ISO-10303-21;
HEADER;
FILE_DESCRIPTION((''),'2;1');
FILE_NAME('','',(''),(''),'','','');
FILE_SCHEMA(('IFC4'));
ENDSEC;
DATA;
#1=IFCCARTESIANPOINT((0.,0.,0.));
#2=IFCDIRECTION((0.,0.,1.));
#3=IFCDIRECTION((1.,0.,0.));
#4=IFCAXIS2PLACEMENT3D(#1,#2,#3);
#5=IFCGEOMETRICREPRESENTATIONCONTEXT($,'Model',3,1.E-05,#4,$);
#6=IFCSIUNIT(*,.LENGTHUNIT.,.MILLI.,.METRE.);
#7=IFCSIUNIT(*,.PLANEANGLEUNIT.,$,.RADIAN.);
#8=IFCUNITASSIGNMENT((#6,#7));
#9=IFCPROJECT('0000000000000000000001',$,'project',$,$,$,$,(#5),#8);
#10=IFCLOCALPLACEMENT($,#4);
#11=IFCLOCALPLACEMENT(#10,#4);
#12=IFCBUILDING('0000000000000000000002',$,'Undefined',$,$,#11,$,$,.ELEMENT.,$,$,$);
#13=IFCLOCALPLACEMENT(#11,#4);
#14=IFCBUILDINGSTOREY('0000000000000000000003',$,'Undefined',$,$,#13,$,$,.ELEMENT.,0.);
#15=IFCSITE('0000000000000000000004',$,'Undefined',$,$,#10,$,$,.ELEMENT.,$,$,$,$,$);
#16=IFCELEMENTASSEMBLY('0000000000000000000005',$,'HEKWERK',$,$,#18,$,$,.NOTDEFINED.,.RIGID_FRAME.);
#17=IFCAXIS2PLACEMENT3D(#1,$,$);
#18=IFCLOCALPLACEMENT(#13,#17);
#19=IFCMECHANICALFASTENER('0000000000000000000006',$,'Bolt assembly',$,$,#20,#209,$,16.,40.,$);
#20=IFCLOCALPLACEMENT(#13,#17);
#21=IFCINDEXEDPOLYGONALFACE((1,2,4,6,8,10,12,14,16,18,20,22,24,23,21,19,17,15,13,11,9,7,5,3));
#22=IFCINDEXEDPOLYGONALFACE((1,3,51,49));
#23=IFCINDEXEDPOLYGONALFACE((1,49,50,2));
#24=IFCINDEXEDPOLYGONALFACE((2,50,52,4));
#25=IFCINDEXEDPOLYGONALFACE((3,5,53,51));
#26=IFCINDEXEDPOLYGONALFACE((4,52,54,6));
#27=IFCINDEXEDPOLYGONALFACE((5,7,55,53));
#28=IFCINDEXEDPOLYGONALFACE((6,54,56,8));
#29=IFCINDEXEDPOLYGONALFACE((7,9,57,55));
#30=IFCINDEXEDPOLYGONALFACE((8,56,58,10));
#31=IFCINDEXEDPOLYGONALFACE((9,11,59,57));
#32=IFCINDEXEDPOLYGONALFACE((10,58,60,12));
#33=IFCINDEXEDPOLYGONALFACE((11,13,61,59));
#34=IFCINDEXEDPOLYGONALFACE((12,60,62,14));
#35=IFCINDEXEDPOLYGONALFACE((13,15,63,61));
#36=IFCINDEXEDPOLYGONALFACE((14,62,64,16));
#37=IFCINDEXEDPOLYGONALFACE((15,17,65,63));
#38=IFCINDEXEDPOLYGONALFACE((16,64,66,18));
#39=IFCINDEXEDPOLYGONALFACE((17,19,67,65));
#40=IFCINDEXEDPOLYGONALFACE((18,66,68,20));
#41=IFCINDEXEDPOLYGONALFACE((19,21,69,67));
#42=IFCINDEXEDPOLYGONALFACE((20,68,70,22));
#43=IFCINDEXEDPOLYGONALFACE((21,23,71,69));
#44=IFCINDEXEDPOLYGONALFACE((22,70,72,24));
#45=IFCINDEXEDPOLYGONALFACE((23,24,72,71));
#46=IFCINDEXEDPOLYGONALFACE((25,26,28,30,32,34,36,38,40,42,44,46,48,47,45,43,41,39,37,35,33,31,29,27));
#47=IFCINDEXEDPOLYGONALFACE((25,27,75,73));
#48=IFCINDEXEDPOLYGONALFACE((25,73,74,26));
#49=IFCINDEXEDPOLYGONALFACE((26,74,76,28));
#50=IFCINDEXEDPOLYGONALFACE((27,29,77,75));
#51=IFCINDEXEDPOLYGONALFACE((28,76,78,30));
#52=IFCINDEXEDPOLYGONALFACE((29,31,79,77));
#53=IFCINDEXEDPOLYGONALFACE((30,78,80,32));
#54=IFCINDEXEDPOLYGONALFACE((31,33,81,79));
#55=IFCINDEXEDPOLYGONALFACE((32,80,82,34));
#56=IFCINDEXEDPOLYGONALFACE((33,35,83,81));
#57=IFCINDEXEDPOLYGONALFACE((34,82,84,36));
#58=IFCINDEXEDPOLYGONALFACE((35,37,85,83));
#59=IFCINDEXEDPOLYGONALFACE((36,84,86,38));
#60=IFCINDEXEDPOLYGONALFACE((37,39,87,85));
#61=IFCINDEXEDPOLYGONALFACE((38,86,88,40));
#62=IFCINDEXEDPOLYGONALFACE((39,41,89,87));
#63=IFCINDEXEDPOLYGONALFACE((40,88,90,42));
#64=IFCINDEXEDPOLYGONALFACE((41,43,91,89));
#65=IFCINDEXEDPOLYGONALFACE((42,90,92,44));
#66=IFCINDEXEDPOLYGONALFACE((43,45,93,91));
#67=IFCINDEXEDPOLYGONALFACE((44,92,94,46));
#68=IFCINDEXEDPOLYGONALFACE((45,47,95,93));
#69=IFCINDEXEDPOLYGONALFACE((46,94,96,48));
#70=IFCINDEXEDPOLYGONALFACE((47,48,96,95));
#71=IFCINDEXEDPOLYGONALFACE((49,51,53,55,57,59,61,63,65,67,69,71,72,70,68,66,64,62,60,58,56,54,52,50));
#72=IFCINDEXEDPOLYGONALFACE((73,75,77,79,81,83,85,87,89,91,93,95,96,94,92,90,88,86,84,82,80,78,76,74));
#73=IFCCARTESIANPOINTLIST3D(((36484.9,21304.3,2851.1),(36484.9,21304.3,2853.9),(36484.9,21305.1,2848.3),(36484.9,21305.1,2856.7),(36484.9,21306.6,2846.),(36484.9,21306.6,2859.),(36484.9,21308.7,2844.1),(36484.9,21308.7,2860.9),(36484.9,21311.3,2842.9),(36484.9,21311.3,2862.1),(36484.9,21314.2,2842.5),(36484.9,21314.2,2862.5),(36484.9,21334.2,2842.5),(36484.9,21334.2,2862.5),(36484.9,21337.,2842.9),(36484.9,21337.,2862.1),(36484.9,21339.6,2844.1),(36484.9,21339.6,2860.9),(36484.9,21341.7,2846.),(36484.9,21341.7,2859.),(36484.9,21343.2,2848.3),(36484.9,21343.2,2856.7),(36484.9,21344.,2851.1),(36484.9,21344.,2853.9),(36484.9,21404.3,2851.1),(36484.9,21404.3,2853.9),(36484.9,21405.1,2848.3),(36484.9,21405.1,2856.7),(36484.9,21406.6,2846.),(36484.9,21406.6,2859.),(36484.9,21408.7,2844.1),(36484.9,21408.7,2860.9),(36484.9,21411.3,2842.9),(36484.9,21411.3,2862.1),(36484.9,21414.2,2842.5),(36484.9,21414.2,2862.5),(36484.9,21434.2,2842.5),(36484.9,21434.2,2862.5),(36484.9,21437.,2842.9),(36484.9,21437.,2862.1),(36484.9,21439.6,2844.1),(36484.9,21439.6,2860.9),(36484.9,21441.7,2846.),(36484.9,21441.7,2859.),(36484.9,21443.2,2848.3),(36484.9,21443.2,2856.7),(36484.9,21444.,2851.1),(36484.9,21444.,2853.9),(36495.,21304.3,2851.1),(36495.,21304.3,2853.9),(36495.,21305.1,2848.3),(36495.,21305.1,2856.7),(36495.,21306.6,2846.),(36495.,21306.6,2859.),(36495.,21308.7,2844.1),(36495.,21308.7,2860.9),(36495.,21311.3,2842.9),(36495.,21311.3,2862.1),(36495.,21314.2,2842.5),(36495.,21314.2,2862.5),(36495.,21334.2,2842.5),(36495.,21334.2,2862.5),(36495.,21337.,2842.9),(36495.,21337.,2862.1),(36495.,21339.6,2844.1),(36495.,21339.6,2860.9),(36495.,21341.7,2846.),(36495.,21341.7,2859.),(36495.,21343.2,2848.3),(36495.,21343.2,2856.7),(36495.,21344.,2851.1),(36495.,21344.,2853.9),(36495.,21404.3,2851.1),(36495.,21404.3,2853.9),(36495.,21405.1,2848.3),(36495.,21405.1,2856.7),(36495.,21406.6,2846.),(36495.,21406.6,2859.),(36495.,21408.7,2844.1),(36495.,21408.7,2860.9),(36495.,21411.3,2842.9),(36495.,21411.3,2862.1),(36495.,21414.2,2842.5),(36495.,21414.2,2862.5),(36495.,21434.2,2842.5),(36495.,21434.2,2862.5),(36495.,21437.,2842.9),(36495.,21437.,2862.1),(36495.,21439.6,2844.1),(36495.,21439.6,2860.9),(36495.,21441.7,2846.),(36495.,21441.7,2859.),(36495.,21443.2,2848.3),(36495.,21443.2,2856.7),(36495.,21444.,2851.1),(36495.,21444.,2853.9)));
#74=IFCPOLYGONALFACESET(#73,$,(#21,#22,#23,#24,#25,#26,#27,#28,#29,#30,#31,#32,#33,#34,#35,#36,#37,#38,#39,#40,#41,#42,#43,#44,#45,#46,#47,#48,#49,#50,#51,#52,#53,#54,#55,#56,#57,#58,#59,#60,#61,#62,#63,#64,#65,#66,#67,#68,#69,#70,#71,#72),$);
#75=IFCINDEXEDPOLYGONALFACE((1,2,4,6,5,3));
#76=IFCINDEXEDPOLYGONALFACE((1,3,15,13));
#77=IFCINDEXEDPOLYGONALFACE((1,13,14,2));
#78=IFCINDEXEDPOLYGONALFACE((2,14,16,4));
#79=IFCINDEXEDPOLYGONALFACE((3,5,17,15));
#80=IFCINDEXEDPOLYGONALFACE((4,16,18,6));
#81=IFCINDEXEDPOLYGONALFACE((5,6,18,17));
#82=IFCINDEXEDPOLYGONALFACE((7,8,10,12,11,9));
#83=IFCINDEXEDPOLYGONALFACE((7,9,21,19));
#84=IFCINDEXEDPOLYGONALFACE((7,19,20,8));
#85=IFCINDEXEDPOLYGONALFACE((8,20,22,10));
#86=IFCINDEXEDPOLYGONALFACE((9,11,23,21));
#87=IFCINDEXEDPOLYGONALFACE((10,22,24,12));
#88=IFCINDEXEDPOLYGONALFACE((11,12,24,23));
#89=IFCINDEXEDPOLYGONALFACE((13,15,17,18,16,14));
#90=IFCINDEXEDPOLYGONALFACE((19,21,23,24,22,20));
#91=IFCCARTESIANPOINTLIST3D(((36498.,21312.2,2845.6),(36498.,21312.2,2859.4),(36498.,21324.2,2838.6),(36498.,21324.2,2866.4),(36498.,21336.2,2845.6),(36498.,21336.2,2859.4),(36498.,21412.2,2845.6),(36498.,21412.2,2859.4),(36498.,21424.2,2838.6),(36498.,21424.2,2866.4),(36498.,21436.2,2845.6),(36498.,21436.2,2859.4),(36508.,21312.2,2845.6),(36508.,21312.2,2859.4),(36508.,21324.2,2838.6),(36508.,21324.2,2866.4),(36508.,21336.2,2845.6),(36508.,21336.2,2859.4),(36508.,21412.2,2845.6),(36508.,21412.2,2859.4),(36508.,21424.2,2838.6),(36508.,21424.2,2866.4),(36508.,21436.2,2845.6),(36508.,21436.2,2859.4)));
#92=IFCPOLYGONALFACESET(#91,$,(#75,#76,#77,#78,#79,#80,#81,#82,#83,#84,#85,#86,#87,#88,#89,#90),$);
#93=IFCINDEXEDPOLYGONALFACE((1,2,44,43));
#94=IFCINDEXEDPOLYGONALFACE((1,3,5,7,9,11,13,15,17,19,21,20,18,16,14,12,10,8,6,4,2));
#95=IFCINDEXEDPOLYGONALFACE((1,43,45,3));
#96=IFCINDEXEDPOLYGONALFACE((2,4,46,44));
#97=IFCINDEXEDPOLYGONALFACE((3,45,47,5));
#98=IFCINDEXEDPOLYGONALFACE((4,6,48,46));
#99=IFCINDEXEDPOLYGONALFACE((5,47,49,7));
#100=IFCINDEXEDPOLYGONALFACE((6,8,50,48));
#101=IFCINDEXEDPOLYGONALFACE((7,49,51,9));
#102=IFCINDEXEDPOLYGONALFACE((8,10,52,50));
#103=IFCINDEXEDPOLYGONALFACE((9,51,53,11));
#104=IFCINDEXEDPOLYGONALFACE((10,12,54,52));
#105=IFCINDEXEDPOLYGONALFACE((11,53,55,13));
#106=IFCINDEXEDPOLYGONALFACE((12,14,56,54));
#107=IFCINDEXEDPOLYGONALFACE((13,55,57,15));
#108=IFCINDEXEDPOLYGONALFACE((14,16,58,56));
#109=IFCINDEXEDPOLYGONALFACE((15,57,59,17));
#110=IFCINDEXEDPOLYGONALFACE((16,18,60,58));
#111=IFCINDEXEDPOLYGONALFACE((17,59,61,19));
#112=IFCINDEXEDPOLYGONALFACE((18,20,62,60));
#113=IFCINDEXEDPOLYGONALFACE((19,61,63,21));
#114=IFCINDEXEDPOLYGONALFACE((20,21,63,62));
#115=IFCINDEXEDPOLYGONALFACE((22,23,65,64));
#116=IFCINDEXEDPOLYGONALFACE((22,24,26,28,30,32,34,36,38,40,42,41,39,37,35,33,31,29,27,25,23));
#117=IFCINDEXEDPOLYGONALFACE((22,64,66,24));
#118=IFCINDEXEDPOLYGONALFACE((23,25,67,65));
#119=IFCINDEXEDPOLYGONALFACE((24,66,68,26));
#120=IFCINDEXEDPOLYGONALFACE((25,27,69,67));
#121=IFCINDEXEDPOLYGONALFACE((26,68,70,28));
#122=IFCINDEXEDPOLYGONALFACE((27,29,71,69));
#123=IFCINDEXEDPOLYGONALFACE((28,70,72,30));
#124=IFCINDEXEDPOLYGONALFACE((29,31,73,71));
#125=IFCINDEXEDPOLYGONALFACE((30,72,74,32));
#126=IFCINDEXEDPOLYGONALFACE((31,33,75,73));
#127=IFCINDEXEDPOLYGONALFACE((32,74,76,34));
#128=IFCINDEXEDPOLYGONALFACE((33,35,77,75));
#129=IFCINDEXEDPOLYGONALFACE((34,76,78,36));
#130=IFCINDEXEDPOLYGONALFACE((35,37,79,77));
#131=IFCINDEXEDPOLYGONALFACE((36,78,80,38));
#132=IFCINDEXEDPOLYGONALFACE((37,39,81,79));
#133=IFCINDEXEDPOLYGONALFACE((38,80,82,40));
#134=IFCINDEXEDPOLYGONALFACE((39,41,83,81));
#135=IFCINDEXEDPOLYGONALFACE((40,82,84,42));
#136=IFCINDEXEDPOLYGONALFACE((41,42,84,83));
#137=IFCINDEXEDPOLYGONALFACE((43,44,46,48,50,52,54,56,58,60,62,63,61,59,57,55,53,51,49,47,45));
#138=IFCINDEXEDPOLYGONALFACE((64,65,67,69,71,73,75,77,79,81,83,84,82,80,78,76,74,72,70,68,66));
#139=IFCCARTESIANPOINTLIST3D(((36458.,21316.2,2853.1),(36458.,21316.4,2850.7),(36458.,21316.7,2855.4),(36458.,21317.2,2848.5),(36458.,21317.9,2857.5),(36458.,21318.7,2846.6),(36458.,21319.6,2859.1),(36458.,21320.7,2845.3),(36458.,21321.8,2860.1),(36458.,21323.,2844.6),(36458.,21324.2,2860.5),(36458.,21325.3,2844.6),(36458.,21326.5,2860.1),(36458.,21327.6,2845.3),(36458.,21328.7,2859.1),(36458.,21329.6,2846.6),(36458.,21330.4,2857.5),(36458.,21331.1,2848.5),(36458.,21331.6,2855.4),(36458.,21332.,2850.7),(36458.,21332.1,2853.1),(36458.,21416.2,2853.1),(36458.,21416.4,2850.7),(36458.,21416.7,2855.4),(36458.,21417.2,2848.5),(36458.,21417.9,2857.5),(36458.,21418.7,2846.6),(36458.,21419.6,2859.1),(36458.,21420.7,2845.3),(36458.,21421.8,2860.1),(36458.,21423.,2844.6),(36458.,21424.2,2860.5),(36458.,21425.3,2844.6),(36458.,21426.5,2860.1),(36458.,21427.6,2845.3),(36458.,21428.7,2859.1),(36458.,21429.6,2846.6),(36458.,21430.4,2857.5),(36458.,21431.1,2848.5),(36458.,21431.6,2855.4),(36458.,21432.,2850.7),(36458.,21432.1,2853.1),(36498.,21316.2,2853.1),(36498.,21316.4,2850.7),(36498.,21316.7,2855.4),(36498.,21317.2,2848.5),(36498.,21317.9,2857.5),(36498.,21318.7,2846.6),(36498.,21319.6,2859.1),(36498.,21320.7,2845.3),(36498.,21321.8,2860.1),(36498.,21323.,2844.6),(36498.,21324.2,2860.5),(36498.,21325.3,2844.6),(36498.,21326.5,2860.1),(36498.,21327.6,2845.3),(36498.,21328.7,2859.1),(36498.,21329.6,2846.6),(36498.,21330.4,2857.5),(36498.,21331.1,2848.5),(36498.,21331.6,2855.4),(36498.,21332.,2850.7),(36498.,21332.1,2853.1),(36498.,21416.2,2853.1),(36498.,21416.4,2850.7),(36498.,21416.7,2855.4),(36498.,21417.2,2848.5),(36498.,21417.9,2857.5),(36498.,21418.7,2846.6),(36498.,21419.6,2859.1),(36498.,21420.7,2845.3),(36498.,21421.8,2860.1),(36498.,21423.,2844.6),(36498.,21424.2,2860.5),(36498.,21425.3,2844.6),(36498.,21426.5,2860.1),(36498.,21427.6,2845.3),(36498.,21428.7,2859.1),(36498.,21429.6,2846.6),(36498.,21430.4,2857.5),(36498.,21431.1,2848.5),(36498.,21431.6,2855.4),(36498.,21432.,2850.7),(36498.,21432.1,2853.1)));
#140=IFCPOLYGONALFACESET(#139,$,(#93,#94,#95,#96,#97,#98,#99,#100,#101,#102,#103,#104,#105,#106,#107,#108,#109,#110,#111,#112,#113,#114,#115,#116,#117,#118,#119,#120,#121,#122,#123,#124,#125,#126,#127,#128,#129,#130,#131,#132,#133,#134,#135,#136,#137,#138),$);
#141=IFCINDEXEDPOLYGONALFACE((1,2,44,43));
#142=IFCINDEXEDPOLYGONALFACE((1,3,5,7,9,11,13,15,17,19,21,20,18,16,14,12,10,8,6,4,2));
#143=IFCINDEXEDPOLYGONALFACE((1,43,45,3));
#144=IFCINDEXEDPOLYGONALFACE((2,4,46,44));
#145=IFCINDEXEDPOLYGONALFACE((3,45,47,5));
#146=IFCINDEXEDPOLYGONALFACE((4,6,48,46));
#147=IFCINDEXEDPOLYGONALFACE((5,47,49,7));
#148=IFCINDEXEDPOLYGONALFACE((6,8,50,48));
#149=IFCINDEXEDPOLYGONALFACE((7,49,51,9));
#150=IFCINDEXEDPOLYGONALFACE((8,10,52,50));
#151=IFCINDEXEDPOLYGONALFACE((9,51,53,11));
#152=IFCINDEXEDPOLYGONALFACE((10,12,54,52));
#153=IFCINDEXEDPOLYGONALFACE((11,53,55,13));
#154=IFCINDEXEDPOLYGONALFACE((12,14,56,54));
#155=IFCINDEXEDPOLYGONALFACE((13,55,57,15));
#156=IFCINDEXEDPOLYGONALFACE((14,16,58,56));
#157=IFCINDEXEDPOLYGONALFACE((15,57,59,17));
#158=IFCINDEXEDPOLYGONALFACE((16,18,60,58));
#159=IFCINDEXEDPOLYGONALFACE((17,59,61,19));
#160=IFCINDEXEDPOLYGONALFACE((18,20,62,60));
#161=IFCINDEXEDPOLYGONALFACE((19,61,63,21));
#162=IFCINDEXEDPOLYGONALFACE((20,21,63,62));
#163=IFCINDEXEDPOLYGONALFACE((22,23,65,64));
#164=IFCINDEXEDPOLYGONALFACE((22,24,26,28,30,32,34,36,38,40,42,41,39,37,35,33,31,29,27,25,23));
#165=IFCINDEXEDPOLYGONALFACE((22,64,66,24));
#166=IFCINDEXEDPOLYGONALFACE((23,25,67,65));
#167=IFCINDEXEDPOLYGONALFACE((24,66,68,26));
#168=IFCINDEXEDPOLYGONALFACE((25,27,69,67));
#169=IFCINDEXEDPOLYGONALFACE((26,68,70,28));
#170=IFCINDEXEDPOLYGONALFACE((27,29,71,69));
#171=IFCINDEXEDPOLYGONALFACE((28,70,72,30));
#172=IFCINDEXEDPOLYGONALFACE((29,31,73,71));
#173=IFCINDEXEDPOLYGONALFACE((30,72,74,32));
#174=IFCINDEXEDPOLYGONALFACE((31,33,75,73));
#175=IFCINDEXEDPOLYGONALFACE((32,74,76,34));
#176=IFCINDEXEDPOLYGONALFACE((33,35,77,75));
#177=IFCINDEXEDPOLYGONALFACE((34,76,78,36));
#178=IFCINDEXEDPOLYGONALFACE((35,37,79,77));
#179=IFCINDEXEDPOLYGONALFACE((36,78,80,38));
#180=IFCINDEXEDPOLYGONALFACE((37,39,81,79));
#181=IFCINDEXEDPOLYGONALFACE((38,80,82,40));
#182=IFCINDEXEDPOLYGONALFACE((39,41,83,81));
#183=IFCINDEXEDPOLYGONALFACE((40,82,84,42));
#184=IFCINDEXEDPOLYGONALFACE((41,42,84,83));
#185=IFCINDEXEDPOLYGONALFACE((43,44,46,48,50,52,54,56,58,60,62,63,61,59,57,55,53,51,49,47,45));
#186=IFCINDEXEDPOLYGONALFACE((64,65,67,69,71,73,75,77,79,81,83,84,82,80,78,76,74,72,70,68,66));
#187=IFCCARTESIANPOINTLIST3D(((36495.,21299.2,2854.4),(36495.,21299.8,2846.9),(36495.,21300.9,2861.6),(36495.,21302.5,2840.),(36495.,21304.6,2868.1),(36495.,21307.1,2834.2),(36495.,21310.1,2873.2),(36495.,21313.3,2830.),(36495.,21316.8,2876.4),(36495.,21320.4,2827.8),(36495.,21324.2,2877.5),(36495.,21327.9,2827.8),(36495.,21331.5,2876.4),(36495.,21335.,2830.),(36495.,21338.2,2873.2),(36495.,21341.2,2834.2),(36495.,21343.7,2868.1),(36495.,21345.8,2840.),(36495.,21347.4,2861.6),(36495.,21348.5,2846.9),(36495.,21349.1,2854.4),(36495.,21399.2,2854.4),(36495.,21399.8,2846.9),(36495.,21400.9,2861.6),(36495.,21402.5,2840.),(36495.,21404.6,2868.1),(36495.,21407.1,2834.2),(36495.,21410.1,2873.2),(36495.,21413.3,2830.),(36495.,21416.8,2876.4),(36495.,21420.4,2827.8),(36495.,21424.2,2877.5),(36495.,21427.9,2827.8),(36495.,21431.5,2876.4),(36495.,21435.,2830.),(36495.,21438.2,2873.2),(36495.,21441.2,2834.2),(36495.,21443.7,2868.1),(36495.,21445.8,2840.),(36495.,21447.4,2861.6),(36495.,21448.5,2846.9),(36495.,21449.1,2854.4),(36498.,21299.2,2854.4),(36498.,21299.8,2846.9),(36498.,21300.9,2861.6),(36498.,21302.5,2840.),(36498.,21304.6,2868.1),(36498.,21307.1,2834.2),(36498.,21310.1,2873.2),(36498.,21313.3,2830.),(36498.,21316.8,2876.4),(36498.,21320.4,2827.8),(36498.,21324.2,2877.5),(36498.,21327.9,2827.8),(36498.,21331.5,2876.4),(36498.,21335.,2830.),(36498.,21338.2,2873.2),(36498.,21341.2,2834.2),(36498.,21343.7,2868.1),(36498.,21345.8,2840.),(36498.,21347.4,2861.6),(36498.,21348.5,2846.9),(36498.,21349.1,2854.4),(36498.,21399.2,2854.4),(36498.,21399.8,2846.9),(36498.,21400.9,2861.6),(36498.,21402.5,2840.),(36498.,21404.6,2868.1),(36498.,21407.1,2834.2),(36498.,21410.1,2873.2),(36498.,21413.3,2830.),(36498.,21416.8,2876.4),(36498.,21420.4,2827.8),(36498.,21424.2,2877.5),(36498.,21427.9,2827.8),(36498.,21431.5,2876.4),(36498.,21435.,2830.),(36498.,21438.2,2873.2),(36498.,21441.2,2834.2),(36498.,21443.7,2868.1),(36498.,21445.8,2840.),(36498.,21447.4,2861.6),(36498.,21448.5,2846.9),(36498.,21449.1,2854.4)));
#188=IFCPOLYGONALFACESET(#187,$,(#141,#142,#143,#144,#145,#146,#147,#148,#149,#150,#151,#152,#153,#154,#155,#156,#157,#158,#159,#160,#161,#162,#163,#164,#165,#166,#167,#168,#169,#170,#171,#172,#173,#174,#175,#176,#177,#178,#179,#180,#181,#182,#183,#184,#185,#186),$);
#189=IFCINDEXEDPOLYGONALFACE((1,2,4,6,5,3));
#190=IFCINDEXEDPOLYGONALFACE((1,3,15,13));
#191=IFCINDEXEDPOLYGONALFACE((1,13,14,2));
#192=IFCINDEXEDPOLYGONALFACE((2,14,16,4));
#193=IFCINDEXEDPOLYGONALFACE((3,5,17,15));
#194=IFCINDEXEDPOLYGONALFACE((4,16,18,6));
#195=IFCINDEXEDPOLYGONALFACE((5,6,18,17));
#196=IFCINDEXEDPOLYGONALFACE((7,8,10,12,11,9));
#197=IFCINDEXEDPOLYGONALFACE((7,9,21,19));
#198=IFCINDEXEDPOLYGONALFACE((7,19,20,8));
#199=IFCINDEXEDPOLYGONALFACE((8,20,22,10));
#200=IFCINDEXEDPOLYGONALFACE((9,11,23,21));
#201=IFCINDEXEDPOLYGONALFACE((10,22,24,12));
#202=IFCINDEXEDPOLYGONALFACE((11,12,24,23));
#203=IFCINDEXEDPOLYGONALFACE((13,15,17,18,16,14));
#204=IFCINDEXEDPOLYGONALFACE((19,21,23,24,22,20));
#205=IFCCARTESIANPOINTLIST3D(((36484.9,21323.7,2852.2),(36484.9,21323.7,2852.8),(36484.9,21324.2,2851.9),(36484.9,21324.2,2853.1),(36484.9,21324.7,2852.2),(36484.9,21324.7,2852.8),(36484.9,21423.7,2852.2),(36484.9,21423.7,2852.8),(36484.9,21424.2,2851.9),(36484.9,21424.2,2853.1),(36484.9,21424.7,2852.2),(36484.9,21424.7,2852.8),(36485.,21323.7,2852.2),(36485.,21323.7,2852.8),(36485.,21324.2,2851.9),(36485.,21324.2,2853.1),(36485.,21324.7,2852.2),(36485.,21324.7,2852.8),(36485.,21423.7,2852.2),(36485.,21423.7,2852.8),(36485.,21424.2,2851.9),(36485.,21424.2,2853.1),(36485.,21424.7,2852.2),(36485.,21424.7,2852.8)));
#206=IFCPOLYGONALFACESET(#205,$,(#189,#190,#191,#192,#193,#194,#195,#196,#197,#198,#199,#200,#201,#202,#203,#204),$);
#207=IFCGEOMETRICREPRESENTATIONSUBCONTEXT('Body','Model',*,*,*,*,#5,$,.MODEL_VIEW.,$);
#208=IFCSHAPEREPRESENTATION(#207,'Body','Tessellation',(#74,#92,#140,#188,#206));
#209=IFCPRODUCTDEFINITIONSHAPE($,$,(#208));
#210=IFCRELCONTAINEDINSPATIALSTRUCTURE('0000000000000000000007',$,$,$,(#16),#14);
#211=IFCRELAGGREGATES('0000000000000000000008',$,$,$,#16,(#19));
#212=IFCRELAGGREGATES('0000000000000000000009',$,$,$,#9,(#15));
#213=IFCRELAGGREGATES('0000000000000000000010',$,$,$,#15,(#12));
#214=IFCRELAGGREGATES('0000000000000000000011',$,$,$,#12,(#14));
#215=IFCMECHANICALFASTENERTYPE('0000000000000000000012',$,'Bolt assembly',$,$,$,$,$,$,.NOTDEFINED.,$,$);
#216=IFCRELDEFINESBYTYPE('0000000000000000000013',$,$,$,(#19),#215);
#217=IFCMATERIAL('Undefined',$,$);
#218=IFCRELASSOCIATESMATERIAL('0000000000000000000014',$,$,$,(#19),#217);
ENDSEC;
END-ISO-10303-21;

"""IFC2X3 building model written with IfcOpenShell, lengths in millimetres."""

from ifc_helpers import new_model, si_unit, frame, frame_2d, origin_with_axes, origin_2d_with_axis, place, context, subcontext, project, spatial, polyline, circle_curve, parameter, trimmed, segment, composite_curve, circle, outline, extrude, source, transform, mapped, material, type_object, element, aggregate, save


model = new_model("IFC2X3")

# Units and contexts
model_context = context("Model", 3, precision=1e-05, world=origin_with_axes())
body_context = subcontext(model_context, "Body", "Model", "MODEL_VIEW")
ifc_project = project(units=[si_unit("LENGTHUNIT", "METRE", prefix="MILLI"), si_unit("PLANEANGLEUNIT", "RADIAN")], contexts=[model_context])

# Site, building, storey
site_placement = place(None, origin_with_axes())
site = spatial("IfcSite", under=ifc_project, at=site_placement, Name="Undefined", CompositionType="ELEMENT")
building_placement = place(site_placement, origin_with_axes())
building = spatial("IfcBuilding", under=site, at=building_placement, Name="Undefined", CompositionType="ELEMENT")
storey_placement = place(building_placement, origin_with_axes())
storey = spatial("IfcBuildingStorey", under=building, at=storey_placement, Name="Undefined", CompositionType="ELEMENT", Elevation=0.0)

# Element assembly
assembly_1_placement = place(storey_placement, origin_with_axes())
assembly_1 = element("IfcElementAssembly", 1, at=assembly_1_placement, inside=storey, Name="HEKWERK", AssemblyPlace="NOTDEFINED", PredefinedType="RIGID_FRAME")

# Shared definitions
ifc_material_1 = material(Name="Undefined")
mechanical_fastener_type = type_object("IfcMechanicalFastenerType", Name="Bolt assembly")

# Mechanical fastener
shared_shape_1 = source(origin_with_axes(), body_context, "Body", "SweptSolid", [
    extrude(outline(composite_curve([segment(polyline([(10.0, 10.0), (10.0, -10.0)]), True, "CONTINUOUS"), segment(trimmed(circle_curve(frame_2d((0.0, -10.0), x_axis=(1.0, 0.0)), 10.0), [parameter(0.0)], [parameter(3.141593)], False, "PARAMETER"), True, "CONTINUOUS"), segment(polyline([(-10.0, -10.0), (-10.0, 10.0)]), True, "CONTINUOUS"), segment(trimmed(circle_curve(frame_2d((0.0, 10.0), x_axis=(-1.0, 0.0)), 10.0), [parameter(0.0)], [parameter(3.141593)], False, "PARAMETER"), True, "DISCONTINUOUS")], self_intersect=False)), frame((0.0, 30.0, 0.0), z_axis=(0.0, 1.0, 0.0), x_axis=(1.0, 0.0, 0.0)), (0.0, 0.0, 1.0), 10.1),
    extrude(outline(polyline([(13.9, 0.0), (6.9, 12.0), (-6.9, 12.0), (-13.9, 0.0), (-6.9, -12.0), (6.9, -12.0), (13.9, 0.0)])), frame((0.0, 17.0, 0.0), z_axis=(0.0, 1.0, 0.0), x_axis=(1.0, 0.0, 0.0)), (0.0, 0.0, 1.0), 10.0),
    extrude(circle(Radius=8.0, at=origin_2d_with_axis()), frame((0.0, 27.0, 0.0), z_axis=(0.0, 1.0, 0.0), x_axis=(1.0, 0.0, 0.0)), (0.0, 0.0, 1.0), 40.0),
    extrude(circle(Radius=25.0, at=origin_2d_with_axis()), frame((0.0, 27.0, 0.0), z_axis=(0.0, 1.0, 0.0), x_axis=(1.0, 0.0, 0.0)), (0.0, 0.0, 1.0), 3.0),
    extrude(outline(polyline([(0.6, 0.0), (0.3, 0.5), (-0.3, 0.5), (-0.6, 0.0), (-0.3, -0.5), (0.3, -0.5), (0.6, 0.0)])), frame((0.0, 40.0, 0.0), z_axis=(0.0, 1.0, 0.0), x_axis=(1.0, 0.0, 0.0)), (0.0, 0.0, 1.0), 0.1),
])
mechanical_fastener_1_placement = place(assembly_1_placement, frame((36525.0, 21374.2, 2852.5), z_axis=(0.0, -1.0, 0.0), x_axis=(0.0, 0.0, 1.0)))
mechanical_fastener_1 = element("IfcMechanicalFastener", 2, at=mechanical_fastener_1_placement, type_object=mechanical_fastener_type, material=ifc_material_1, Name="Bolt assembly", NominalDiameter=16.0, NominalLength=40.0, context=body_context, shape_type="MappedRepresentation", body=[
    mapped(shared_shape_1, transform((0.0, 0.0, 50.0))),
    mapped(shared_shape_1, transform((0.0, 0.0, -50.0))),
])
aggregate(assembly_1, [mechanical_fastener_1])

save(model, "model.ifc")
